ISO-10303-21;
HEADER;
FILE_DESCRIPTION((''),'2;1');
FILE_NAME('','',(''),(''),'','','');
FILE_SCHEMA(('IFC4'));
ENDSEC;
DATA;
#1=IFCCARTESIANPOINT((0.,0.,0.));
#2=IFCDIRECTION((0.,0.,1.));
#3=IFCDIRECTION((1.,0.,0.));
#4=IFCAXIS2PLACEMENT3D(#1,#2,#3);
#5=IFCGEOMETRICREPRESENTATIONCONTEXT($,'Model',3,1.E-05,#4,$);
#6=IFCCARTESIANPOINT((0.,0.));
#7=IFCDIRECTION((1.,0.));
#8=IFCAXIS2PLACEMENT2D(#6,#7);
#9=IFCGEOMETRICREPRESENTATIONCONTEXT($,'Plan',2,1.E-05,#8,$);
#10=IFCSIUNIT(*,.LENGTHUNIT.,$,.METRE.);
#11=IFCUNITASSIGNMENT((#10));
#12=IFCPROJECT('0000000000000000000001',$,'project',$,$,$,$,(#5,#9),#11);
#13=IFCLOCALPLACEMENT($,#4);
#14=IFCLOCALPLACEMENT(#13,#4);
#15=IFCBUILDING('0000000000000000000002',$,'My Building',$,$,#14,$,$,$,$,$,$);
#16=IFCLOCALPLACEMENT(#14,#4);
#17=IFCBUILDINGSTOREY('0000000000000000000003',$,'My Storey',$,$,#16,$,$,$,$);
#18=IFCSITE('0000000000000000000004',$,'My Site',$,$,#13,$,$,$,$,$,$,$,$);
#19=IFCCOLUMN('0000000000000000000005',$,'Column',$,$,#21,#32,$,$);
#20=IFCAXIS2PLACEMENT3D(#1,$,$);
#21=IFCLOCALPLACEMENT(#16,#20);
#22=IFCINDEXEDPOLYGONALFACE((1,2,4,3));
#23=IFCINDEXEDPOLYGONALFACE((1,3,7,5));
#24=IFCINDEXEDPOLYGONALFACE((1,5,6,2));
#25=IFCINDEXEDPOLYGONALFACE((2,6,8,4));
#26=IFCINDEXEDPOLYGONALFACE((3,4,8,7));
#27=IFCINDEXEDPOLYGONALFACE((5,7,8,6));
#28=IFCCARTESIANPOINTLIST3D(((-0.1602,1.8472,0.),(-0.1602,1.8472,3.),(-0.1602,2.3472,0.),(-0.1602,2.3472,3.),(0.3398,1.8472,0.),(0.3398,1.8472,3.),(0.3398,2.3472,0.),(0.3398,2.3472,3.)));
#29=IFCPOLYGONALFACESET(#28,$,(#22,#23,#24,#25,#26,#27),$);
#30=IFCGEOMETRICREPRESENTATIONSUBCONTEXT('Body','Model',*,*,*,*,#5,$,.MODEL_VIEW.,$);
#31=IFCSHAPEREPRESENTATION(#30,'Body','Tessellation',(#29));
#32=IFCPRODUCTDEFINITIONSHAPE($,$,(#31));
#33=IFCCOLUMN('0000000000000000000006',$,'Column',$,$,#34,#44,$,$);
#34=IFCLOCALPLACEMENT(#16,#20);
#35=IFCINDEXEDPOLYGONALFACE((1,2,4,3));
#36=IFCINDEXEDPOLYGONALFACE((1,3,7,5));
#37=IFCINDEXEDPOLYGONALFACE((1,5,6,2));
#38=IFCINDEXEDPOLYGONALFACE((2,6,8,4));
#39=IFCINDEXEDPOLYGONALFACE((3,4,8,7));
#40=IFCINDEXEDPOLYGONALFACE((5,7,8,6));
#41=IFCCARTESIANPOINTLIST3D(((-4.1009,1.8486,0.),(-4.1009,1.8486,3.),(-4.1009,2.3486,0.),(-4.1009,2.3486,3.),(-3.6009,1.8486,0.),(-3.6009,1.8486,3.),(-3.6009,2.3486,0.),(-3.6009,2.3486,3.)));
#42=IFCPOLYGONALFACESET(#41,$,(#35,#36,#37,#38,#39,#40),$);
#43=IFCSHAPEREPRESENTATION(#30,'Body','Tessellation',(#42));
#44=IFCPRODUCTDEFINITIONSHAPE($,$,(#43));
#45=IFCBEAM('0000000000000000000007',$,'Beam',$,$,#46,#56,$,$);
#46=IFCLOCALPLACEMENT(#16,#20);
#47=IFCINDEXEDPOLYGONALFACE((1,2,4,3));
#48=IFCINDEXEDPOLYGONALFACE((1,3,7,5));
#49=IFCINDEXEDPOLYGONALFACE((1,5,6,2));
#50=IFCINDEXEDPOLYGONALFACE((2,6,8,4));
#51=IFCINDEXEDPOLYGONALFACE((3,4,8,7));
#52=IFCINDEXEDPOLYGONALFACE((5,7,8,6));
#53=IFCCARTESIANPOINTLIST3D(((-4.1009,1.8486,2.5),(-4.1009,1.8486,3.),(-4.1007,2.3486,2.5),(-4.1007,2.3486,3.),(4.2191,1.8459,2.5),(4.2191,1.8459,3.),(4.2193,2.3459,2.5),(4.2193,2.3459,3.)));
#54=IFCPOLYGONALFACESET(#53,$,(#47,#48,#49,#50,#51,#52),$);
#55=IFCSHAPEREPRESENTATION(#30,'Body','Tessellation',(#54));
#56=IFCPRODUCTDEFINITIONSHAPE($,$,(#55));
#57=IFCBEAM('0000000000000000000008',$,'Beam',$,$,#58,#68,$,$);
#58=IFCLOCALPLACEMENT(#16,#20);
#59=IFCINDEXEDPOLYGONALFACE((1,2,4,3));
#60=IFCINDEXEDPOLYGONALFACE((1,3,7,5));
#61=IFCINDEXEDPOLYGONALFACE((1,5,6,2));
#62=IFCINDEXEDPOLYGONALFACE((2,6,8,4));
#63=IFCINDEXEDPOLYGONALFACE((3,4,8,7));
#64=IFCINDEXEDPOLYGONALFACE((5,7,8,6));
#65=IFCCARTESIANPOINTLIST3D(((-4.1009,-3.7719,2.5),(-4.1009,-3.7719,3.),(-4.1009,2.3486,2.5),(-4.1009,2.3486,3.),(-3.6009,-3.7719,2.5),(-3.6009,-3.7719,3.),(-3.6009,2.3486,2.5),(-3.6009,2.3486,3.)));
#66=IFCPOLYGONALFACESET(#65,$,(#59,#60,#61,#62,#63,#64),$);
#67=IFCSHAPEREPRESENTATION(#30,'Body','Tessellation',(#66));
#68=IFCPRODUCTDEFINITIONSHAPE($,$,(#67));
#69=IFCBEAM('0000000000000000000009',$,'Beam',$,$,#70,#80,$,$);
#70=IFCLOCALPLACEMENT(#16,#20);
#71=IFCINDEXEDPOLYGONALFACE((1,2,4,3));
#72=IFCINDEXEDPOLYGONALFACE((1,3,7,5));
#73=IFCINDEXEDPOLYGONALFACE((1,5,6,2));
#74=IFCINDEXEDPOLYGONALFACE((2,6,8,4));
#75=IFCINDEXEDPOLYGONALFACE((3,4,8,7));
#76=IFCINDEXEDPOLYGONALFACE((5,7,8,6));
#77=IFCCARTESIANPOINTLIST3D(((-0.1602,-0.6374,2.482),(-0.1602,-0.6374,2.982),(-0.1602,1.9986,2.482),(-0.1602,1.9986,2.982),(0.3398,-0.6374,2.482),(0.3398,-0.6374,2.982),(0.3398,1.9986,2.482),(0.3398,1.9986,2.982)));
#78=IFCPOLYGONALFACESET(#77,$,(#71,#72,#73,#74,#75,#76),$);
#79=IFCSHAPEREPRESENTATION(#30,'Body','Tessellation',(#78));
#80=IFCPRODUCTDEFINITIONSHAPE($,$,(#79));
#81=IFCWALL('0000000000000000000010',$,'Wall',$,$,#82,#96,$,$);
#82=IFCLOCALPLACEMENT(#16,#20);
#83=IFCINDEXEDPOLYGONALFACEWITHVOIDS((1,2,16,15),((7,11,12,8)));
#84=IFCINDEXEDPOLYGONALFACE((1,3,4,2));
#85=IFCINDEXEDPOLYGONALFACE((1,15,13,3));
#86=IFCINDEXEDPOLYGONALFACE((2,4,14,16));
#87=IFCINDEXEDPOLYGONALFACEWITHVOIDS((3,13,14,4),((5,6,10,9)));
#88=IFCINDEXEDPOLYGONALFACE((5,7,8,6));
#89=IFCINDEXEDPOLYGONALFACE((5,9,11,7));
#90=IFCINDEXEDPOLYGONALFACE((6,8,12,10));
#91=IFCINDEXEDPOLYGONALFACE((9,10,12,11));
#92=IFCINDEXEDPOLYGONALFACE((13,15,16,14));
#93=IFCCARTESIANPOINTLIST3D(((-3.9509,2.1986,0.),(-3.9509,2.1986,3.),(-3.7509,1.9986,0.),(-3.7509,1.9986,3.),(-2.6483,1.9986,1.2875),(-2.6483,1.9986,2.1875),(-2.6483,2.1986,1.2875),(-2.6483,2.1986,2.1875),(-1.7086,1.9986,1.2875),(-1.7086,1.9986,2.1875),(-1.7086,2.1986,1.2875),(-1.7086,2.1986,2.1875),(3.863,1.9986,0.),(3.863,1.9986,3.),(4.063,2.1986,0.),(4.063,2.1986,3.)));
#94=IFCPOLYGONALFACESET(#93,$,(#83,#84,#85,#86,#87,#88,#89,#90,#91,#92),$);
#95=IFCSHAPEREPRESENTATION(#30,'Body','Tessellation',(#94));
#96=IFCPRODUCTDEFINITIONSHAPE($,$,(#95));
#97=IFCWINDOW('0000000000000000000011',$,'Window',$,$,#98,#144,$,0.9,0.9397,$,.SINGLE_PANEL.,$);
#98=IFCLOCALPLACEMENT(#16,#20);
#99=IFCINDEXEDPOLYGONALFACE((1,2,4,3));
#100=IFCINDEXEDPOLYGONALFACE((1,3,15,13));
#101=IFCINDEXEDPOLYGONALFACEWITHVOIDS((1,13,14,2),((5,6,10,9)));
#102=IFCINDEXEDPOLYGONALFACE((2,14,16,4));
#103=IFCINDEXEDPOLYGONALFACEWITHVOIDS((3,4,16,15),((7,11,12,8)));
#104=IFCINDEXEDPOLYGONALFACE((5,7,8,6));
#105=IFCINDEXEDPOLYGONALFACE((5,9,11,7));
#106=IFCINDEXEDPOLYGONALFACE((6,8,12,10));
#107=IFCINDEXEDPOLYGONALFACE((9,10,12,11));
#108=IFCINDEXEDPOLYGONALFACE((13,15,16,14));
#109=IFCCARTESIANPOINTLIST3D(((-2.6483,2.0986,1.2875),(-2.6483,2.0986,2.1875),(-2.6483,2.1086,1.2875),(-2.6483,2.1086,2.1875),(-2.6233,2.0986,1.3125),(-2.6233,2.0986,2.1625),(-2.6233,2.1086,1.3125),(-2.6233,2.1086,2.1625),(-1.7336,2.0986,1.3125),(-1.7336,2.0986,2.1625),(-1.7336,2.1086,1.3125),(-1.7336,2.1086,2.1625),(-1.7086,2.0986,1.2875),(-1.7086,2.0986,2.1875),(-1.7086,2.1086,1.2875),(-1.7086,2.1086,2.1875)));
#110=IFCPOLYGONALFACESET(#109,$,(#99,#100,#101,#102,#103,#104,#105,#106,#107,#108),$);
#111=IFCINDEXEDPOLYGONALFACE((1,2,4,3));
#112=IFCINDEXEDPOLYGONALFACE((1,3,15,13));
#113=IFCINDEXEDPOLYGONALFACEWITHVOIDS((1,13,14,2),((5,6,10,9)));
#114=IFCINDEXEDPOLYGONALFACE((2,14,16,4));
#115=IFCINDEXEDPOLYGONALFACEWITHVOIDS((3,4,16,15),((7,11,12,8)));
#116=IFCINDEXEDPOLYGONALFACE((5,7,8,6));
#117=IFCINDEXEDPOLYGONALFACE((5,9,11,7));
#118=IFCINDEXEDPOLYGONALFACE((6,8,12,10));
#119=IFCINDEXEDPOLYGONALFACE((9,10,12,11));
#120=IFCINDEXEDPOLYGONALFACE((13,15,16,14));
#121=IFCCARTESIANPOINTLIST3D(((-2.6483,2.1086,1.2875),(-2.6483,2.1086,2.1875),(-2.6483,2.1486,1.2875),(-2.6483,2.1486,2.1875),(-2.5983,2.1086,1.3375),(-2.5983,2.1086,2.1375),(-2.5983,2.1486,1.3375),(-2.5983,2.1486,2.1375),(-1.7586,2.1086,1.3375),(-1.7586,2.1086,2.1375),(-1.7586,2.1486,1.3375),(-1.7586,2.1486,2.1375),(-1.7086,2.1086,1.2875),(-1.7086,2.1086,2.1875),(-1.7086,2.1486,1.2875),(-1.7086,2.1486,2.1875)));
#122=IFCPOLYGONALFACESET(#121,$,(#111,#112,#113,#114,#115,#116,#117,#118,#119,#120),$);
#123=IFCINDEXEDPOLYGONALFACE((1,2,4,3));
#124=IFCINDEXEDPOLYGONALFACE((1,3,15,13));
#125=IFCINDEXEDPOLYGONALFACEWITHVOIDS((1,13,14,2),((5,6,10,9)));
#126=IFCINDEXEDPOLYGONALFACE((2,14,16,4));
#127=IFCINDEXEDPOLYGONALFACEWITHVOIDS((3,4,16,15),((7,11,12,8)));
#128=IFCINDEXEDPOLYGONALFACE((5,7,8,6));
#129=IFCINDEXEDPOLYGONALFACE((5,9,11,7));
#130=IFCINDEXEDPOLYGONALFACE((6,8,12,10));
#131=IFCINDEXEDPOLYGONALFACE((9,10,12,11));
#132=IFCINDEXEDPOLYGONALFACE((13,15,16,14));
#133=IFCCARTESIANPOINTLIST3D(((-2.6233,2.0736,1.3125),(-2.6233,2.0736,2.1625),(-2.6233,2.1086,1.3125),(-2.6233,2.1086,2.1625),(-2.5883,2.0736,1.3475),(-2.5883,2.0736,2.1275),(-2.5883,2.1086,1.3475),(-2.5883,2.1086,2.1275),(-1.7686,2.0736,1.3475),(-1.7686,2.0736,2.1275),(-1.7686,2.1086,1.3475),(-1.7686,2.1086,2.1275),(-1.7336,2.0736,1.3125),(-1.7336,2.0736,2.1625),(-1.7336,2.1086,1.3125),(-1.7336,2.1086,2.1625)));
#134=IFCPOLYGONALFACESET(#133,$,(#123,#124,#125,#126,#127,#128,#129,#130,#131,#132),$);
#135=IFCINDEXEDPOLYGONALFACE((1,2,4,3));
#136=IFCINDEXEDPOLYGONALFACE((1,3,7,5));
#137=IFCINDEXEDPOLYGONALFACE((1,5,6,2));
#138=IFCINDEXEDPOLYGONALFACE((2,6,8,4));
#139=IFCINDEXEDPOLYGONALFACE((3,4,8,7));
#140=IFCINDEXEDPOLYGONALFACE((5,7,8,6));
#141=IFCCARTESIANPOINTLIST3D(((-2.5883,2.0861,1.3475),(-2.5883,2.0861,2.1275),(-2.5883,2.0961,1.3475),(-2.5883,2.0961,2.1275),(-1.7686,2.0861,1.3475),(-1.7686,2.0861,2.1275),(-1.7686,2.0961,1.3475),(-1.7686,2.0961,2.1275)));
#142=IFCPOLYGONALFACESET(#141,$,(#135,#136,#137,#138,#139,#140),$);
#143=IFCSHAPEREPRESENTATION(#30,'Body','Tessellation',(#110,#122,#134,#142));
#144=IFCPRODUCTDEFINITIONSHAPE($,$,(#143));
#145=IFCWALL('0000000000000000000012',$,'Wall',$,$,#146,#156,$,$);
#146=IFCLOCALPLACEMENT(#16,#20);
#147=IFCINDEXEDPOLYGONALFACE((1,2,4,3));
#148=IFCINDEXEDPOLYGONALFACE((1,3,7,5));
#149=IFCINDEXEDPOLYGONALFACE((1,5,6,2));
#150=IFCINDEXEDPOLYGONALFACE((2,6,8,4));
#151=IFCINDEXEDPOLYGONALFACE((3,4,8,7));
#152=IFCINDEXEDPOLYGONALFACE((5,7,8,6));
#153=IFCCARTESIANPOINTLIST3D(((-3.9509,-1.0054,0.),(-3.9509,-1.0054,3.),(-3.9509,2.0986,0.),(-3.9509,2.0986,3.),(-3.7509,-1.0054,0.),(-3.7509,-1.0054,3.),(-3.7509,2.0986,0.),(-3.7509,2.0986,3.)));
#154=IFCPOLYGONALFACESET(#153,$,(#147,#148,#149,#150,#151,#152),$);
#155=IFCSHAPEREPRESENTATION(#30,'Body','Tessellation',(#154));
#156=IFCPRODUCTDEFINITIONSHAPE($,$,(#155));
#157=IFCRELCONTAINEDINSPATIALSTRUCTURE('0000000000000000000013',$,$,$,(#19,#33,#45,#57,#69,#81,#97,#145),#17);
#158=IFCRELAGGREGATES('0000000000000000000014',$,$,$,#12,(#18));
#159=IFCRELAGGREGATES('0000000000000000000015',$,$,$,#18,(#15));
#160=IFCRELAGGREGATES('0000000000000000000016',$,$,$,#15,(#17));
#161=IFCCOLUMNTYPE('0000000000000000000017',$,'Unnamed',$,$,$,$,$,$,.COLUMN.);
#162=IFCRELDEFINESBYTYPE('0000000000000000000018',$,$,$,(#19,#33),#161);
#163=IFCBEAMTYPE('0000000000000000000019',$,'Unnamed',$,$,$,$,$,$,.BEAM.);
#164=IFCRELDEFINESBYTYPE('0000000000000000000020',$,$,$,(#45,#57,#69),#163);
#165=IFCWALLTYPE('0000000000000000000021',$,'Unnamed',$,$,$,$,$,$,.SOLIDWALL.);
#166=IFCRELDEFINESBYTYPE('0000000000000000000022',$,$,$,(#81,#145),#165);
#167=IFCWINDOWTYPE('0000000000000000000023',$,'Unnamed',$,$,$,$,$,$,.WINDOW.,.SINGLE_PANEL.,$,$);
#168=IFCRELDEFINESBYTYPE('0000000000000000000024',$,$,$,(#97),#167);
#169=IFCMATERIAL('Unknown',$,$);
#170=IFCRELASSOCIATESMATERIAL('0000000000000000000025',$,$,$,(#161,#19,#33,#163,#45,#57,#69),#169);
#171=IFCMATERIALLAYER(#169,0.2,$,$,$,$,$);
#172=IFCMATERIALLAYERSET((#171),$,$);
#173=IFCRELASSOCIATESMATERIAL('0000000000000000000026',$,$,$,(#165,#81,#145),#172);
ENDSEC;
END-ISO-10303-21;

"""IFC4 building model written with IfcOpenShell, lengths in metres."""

from ifc_helpers import new_model, entity, si_unit, frame, origin_with_axes, origin_2d_with_axis, place, context, subcontext, project, spatial, line, indexed_curve, rectangle, outline, extrude, shape, source, transform, mapped, material, layer, layer_set, layer_usage, material_profile, profile_set, profile_usage, type_object, type_shapes, element, fill, save


model = new_model("IFC4")

# Units and contexts
model_context = context("Model", 3, precision=1e-05, world=origin_with_axes())
plan_context = context("Plan", 2, precision=1e-05, world=origin_2d_with_axis())
body_context_1 = subcontext(model_context, "Body", "Model", "MODEL_VIEW")
body_context_2 = subcontext(plan_context, "Body", "Plan", "PLAN_VIEW")
ifc_project = project(units=[si_unit("LENGTHUNIT", "METRE")], contexts=[model_context, plan_context])

# Site, building, storey
site_placement = place(None, origin_with_axes())
site = spatial("IfcSite", under=ifc_project, at=site_placement, Name="My Site")
building_placement = place(site_placement, origin_with_axes())
building = spatial("IfcBuilding", under=site, at=building_placement, Name="My Building")
storey_placement = place(building_placement, origin_with_axes())
storey = spatial("IfcBuildingStorey", under=building, at=storey_placement, Name="My Storey")

# Columns
ifc_material = material(Name="Unknown")
ifc_material_profile_1 = material_profile(ifc_material, rectangle(XDim=0.5, YDim=0.5))
ifc_profile_set_1 = profile_set([ifc_material_profile_1])
ifc_profile_usage_1 = profile_usage(ifc_profile_set_1, cardinal=5)
column_type = type_object("IfcColumnType", Name="Unnamed", PredefinedType="COLUMN", material=ifc_profile_set_1)
column_1_placement = place(storey_placement, frame((0.0898, 2.0972, 0.0), z_axis=(0.0, 0.0, 1.0), x_axis=(1.0, 0.0, 0.0)))
element("IfcColumn", 1, at=column_1_placement, inside=storey, type_object=column_type, material=ifc_profile_usage_1, Name="Column", context=body_context_1, shape_type="SweptSolid", body=[
    extrude(rectangle(XDim=0.5, YDim=0.5), origin_with_axes(), (0.0, 0.0, 1.0), 3.0),
])
ifc_profile_usage_2 = profile_usage(ifc_profile_set_1, cardinal=5)
column_2_placement = place(storey_placement, frame((-3.8509, 2.0986, 0.0), z_axis=(0.0, 0.0, 1.0), x_axis=(1.0, 0.0, 0.0)))
element("IfcColumn", 2, at=column_2_placement, inside=storey, type_object=column_type, material=ifc_profile_usage_2, Name="Column", context=body_context_1, shape_type="SweptSolid", body=[
    extrude(rectangle(XDim=0.5, YDim=0.5), origin_with_axes(), (0.0, 0.0, 1.0), 3.0),
])

# Beams
ifc_material_profile_2 = material_profile(ifc_material, rectangle(XDim=0.5, YDim=0.5))
ifc_profile_set_2 = profile_set([ifc_material_profile_2])
ifc_profile_usage_3 = profile_usage(ifc_profile_set_2, cardinal=5)
beam_type = type_object("IfcBeamType", Name="Unnamed", PredefinedType="BEAM", material=ifc_profile_set_2)
beam_1_placement = place(storey_placement, frame((-4.1008, 2.0986, 2.75), z_axis=(1.0, -0.000323, 0.0), x_axis=(0.000323, 1.0, 0.0)))
element("IfcBeam", 3, at=beam_1_placement, inside=storey, type_object=beam_type, material=ifc_profile_usage_3, Name="Beam", context=body_context_1, shape_type="SweptSolid", body=[
    extrude(rectangle(XDim=0.5, YDim=0.5), origin_with_axes(), (0.0, 0.0, 1.0), 8.32),
])
ifc_profile_usage_4 = profile_usage(ifc_profile_set_2, cardinal=5)
beam_2_placement = place(storey_placement, frame((-3.8509, 2.3486, 2.75), z_axis=(0.0, -1.0, 0.0), x_axis=(1.0, 0.0, 0.0)))
element("IfcBeam", 4, at=beam_2_placement, inside=storey, type_object=beam_type, material=ifc_profile_usage_4, Name="Beam", context=body_context_1, shape_type="SweptSolid", body=[
    extrude(rectangle(XDim=0.5, YDim=0.5), origin_with_axes(), (0.0, 0.0, 1.0), 6.1205),
])
ifc_profile_usage_5 = profile_usage(ifc_profile_set_2, cardinal=5)
beam_3_placement = place(storey_placement, frame((0.0898, 1.9986, 2.732), z_axis=(0.0, -1.0, 0.0), x_axis=(1.0, 0.0, 0.0)))
element("IfcBeam", 5, at=beam_3_placement, inside=storey, type_object=beam_type, material=ifc_profile_usage_5, Name="Beam", context=body_context_1, shape_type="SweptSolid", body=[
    extrude(rectangle(XDim=0.5, YDim=0.5), origin_with_axes(), (0.0, 0.0, 1.0), 2.6361),
])

# Wall, opening, window
ifc_layer_1 = layer(ifc_material, 0.2)
ifc_layer_set_1 = layer_set([ifc_layer_1])
ifc_layer_usage_1 = layer_usage(ifc_layer_set_1, "AXIS2", "POSITIVE", 0.0)
wall_type_1 = type_object("IfcWallType", Name="Unnamed", PredefinedType="SOLIDWALL", material=ifc_layer_set_1)
wall_1_placement = place(storey_placement, frame((-3.9509, 1.9986, 0.0), z_axis=(0.0, 0.0, 1.0), x_axis=(1.0, 0.0, 0.0)))
wall_1 = element("IfcWall", 6, at=wall_1_placement, inside=storey, type_object=wall_type_1, material=ifc_layer_usage_1, Name="Wall", context=body_context_1, shape_type="SweptSolid", body=[
    extrude(outline(indexed_curve([(0.2, 0.0), (0.0, 0.2), (8.0138, 0.2), (7.8138, 0.0)], segments=[line(1, 2, 3, 4, 1)])), origin_with_axes(), (0.0, 0.0, 1.0), 3.0),
])
shared_shape_1 = source(origin_with_axes(), body_context_1, "Body", "SweptSolid", [
    extrude(outline(indexed_curve([(0.0, 0.0), (0.9397, 0.0), (0.9397, 0.9), (0.0, 0.9)], segments=[line(1, 2, 3, 4, 1)])), frame((0.0, -0.6, 0.0), z_axis=(0.0, -1.0, 0.0), x_axis=(1.0, 0.0, 0.0)), (0.0, 0.0, -1.0), 1.2),
])
opening_1_placement = place(wall_1_placement, frame((2.2423, 0.2, 1.2875), z_axis=(0.0, 0.0, 1.0), x_axis=(-1.0, 0.0, 0.0)))
opening_1 = element("IfcOpeningElement", 7, at=opening_1_placement, cuts=wall_1, PredefinedType="OPENING", context=body_context_1, shape_type="MappedRepresentation", body=[
    mapped(shared_shape_1, transform((0.0, 0.0, 0.0), x_axis=(1.0, 0.0, 0.0), y_axis=(0.0, 1.0, 0.0), z_axis=(0.0, 0.0, 1.0), scale=1.0)),
])
window_type = type_object("IfcWindowType", Name="Unnamed", PartitioningType="SINGLE_PANEL", PredefinedType="WINDOW")
shared_shape_2 = source(origin_with_axes(), body_context_1, "Body", "SweptSolid", [
    extrude(outline(indexed_curve([(0.0, 0.0), (0.9397, 0.0), (0.9397, 0.9), (0.0, 0.9)], segments=[line(1, 2, 3, 4, 1)]), holes=[indexed_curve([(0.025, 0.025), (0.9147, 0.025), (0.9147, 0.875), (0.025, 0.875)], segments=[line(1, 2, 3, 4, 1)])]), frame((0.0, 0.09, 0.0), z_axis=(0.0, -1.0, 0.0), x_axis=(1.0, 0.0, 0.0)), (0.0, 0.0, -1.0), 0.01),
    extrude(outline(indexed_curve([(0.0, 0.0), (0.9397, 0.0), (0.9397, 0.9), (0.0, 0.9)], segments=[line(1, 2, 3, 4, 1)]), holes=[indexed_curve([(0.05, 0.05), (0.8897, 0.05), (0.8897, 0.85), (0.05, 0.85)], segments=[line(1, 2, 3, 4, 1)])]), frame((0.0, 0.05, 0.0), z_axis=(0.0, -1.0, 0.0), x_axis=(1.0, 0.0, 0.0)), (0.0, 0.0, -1.0), 0.04),
    extrude(outline(indexed_curve([(0.0, 0.0), (0.8897, 0.0), (0.8897, 0.85), (0.0, 0.85)], segments=[line(1, 2, 3, 4, 1)]), holes=[indexed_curve([(0.035, 0.035), (0.8547, 0.035), (0.8547, 0.815), (0.035, 0.815)], segments=[line(1, 2, 3, 4, 1)])]), frame((0.025, 0.09, 0.025), z_axis=(0.0, -1.0, 0.0), x_axis=(1.0, 0.0, 0.0)), (0.0, 0.0, -1.0), 0.035),
    extrude(outline(indexed_curve([(0.035, 0.035), (0.8547, 0.035), (0.8547, 0.815), (0.035, 0.815)], segments=[line(1, 2, 3, 4, 1)])), frame((0.025, 0.1025, 0.025), z_axis=(0.0, -1.0, 0.0), x_axis=(1.0, 0.0, 0.0)), (0.0, 0.0, -1.0), 0.01),
])
shared_shape_3 = source(origin_with_axes(), body_context_2, "Body", "Curve2D", [
    entity("IfcIndexedPolyCurve", entity("IfcCartesianPointList2D", [[0.05, 0.05], [0.8897, 0.05]])),
    entity("IfcIndexedPolyCurve", entity("IfcCartesianPointList2D", [[0.0, 0.1], [0.025, 0.1], [0.025, 0.09], [0.05, 0.09], [0.05, 0.05], [0.0, 0.05]]), [entity("IfcLineIndex", [1, 2, 3, 4, 5, 6, 1])]),
    entity("IfcIndexedPolyCurve", entity("IfcCartesianPointList2D", [[0.9397, 0.1], [0.9147, 0.1], [0.9147, 0.09], [0.8897, 0.09], [0.8897, 0.05], [0.9397, 0.05]]), [entity("IfcLineIndex", [1, 2, 3, 4, 5, 6, 1])]),
    entity("IfcIndexedPolyCurve", entity("IfcCartesianPointList2D", [[0.025, 0.09], [0.06, 0.09], [0.06, 0.125], [0.025, 0.125]]), [entity("IfcLineIndex", [1, 2, 3, 4, 1])]),
    entity("IfcIndexedPolyCurve", entity("IfcCartesianPointList2D", [[0.9147, 0.09], [0.8797, 0.09], [0.8797, 0.125], [0.9147, 0.125]]), [entity("IfcLineIndex", [1, 2, 3, 4, 1])]),
    entity("IfcIndexedPolyCurve", entity("IfcCartesianPointList2D", [[0.06, 0.09], [0.8797, 0.09]])),
    entity("IfcIndexedPolyCurve", entity("IfcCartesianPointList2D", [[0.06, 0.125], [0.8797, 0.125]])),
    entity("IfcIndexedPolyCurve", entity("IfcCartesianPointList2D", [[0.06, 0.1075], [0.8797, 0.1075]])),
])
type_shapes(window_type, [shared_shape_2, shared_shape_3])
window_placement = place(opening_1_placement, origin_with_axes())
window = element("IfcWindow", 8, at=window_placement, inside=storey, type_object=window_type, Name="Window", OverallHeight=0.9, OverallWidth=0.9397, PartitioningType="SINGLE_PANEL", shapes=[
    shape(body_context_1, "Body", "MappedRepresentation", [mapped(shared_shape_2, transform((0.0, 0.0, 0.0), x_axis=(1.0, 0.0, 0.0), y_axis=(0.0, 1.0, 0.0), z_axis=(0.0, 0.0, 1.0), scale=1.0))]),
    shape(body_context_2, "Body", "MappedRepresentation", [mapped(shared_shape_3, transform((0.0, 0.0, 0.0), x_axis=(1.0, 0.0, 0.0), y_axis=(0.0, 1.0, 0.0), z_axis=(0.0, 0.0, 1.0), scale=1.0))]),
])
fill(opening_1, window)

# Wall
ifc_layer_usage_2 = layer_usage(ifc_layer_set_1, "AXIS2", "POSITIVE", 0.0)
wall_2_placement = place(storey_placement, frame((-3.9509, 2.0986, 0.0), z_axis=(0.0, 0.0, 1.0), x_axis=(0.0, -1.0, 0.0)))
element("IfcWall", 9, at=wall_2_placement, inside=storey, type_object=wall_type_1, material=ifc_layer_usage_2, Name="Wall", context=body_context_1, shape_type="SweptSolid", body=[
    extrude(outline(indexed_curve([(0.0, 0.0), (0.0, 0.2), (3.1041, 0.2), (3.1041, 0.0)], segments=[line(1, 2, 3, 4, 1)])), origin_with_axes(), (0.0, 0.0, 1.0), 3.0),
])

save(model, "model.ifc")
